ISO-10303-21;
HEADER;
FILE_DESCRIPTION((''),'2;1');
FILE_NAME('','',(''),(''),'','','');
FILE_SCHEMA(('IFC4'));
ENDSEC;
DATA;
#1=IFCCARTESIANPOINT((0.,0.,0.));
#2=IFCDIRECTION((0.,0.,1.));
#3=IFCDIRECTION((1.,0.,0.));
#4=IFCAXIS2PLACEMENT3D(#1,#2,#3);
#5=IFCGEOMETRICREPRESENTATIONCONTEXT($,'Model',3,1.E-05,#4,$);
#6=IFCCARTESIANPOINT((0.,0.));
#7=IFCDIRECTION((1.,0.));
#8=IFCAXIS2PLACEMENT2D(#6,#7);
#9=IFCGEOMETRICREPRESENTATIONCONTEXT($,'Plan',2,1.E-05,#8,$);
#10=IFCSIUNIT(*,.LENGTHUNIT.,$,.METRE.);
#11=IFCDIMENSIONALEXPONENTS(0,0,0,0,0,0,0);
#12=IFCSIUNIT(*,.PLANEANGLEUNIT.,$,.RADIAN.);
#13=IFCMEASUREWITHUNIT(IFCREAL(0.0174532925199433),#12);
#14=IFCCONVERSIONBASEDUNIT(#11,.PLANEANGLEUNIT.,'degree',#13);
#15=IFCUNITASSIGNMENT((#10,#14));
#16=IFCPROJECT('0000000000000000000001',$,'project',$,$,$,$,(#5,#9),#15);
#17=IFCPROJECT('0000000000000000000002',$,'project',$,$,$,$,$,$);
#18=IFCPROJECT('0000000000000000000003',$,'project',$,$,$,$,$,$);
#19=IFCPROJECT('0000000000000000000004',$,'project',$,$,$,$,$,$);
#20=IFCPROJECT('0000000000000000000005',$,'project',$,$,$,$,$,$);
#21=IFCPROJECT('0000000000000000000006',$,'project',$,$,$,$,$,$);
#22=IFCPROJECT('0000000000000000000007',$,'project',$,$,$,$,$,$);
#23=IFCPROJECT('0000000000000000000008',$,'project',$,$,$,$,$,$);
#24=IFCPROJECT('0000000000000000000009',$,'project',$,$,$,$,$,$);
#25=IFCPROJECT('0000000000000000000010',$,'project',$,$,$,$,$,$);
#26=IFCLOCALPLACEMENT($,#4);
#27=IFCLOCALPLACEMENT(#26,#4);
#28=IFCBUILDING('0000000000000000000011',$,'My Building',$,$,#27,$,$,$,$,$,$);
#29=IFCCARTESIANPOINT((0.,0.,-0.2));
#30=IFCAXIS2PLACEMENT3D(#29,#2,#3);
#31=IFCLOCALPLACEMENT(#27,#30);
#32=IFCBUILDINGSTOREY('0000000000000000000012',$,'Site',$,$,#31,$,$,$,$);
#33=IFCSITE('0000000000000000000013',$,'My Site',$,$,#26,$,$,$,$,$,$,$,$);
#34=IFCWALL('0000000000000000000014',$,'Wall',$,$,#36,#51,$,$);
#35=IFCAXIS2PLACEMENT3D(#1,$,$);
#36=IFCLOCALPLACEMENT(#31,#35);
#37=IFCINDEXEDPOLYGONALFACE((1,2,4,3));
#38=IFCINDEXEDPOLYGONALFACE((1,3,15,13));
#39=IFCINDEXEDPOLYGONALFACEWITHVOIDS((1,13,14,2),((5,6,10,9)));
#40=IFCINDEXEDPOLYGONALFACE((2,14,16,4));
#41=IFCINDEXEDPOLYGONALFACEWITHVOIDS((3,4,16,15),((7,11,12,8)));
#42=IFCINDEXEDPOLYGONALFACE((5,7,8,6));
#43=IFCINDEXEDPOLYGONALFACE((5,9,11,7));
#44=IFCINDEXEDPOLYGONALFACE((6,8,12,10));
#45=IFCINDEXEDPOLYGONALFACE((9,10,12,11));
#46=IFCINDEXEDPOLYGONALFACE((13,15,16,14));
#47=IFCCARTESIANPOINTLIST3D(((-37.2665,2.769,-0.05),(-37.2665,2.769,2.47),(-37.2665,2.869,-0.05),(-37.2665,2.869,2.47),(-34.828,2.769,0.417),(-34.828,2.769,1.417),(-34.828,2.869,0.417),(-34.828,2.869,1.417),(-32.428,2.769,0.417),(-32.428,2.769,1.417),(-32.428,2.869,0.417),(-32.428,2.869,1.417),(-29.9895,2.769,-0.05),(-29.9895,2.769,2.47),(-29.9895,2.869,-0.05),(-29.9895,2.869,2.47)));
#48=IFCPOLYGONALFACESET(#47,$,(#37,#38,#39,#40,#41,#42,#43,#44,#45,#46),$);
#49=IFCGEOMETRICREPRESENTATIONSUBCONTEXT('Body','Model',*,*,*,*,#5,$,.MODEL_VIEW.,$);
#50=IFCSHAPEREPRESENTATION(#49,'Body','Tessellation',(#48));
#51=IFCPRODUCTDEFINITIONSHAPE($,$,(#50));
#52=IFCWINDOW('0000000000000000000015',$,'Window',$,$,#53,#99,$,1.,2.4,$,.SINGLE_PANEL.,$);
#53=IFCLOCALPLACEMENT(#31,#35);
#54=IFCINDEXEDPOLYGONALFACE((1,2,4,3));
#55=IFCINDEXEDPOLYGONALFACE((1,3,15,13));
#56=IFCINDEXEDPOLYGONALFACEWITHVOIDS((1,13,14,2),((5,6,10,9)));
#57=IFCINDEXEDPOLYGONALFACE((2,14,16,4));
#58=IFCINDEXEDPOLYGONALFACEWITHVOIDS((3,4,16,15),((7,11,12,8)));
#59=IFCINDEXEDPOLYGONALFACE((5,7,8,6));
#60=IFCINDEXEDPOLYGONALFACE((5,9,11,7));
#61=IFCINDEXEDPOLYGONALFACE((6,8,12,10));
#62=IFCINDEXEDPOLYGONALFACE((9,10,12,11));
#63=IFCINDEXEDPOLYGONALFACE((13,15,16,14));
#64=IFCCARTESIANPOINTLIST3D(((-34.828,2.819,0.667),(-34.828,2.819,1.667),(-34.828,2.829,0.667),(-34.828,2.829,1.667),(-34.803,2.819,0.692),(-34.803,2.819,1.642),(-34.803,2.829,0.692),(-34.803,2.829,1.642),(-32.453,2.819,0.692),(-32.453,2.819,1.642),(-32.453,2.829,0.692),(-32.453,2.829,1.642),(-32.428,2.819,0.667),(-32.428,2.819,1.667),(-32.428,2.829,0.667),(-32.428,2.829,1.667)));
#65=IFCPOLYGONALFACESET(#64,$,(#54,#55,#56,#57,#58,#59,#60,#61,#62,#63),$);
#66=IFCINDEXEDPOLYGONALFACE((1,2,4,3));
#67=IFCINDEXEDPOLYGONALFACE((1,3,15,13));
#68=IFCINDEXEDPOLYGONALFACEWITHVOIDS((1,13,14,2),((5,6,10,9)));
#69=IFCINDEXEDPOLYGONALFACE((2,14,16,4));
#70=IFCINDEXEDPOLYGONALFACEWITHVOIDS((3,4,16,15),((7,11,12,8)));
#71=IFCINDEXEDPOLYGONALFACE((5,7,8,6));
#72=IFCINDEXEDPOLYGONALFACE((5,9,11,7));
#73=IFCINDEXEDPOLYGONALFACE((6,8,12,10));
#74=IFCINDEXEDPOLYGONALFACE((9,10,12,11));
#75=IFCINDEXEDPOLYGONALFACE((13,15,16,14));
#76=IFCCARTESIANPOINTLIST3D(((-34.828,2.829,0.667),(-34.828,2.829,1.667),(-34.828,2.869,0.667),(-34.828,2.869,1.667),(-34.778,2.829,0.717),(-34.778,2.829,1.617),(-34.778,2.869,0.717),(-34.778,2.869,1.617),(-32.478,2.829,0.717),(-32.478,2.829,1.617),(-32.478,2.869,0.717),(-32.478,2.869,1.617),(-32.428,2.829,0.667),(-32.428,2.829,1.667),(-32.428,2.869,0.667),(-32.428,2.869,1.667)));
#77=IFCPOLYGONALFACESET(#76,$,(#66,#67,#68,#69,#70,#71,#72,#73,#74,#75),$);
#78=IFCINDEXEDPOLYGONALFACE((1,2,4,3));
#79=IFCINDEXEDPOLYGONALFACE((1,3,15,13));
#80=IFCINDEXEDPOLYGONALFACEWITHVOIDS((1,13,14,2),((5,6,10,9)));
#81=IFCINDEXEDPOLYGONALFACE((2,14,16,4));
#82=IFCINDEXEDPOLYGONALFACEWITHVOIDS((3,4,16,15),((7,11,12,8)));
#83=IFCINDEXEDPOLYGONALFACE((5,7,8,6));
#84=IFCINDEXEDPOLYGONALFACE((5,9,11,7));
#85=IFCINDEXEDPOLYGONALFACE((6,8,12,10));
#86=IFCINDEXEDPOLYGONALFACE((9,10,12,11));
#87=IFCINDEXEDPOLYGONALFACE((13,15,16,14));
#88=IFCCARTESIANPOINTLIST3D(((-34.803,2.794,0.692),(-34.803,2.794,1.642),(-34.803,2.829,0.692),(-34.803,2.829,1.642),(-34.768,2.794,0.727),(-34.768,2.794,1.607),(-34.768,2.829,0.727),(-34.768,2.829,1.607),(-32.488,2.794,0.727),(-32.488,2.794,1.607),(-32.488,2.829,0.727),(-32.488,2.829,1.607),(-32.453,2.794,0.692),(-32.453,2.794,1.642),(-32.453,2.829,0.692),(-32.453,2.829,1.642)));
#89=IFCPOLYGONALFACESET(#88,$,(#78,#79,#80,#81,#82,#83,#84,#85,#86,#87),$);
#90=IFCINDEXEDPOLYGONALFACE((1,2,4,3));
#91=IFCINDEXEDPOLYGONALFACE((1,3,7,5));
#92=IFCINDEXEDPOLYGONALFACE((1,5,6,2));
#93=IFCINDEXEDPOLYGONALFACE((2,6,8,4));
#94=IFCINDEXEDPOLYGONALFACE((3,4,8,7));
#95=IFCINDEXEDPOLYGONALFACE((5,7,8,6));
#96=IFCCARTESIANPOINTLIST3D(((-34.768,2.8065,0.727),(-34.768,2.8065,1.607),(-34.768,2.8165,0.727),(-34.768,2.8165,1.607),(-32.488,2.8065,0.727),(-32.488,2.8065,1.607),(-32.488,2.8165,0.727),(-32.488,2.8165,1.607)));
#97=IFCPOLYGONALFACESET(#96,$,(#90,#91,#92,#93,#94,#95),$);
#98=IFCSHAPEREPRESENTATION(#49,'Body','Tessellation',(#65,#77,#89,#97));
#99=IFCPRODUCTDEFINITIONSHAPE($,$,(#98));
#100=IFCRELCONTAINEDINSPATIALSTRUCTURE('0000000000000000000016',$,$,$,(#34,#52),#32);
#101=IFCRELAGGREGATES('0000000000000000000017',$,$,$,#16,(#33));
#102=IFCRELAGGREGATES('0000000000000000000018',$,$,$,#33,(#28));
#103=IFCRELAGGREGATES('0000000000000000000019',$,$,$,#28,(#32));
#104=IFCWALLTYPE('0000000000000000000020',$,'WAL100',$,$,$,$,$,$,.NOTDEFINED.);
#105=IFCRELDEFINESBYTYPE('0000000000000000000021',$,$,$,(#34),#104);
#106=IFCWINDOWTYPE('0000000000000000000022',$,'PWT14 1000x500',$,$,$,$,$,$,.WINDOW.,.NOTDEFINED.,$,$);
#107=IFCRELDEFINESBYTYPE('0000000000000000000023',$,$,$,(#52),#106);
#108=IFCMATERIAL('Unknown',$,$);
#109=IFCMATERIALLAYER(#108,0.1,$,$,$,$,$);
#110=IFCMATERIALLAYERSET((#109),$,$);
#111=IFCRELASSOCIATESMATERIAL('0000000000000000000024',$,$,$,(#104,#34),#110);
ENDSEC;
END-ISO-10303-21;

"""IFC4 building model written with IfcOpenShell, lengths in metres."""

from ifc_helpers import new_model, entity, si_unit, converted_unit, frame, origin_with_axes, origin_2d_with_axis, place, context, subcontext, project, spatial, line, indexed_curve, outline, extrude, shape, source, transform, mapped, material, layer, layer_set, layer_usage, type_object, type_shapes, element, fill, save


model = new_model("IFC4")

# Units and contexts
model_context = context("Model", 3, precision=1e-05, world=origin_with_axes())
plan_context = context("Plan", 2, precision=1e-05, world=origin_2d_with_axis())
body_context_1 = subcontext(model_context, "Body", "Model", "MODEL_VIEW")
body_context_2 = subcontext(plan_context, "Body", "Plan", "PLAN_VIEW")
ifc_project_1 = project(units=[si_unit("LENGTHUNIT", "METRE"), converted_unit("PLANEANGLEUNIT", "degree", entity("IfcReal", 0.0174532925199433), si_unit("PLANEANGLEUNIT", "RADIAN"), dimensions=[0, 0, 0, 0, 0, 0, 0])], contexts=[model_context, plan_context])
ifc_project_2 = project()
ifc_project_3 = project()
ifc_project_4 = project()
ifc_project_5 = project()
ifc_project_6 = project()
ifc_project_7 = project()
ifc_project_8 = project()
ifc_project_9 = project()
ifc_project_10 = project()

# Site, building, storey
site_placement = place(None, origin_with_axes())
site = spatial("IfcSite", under=ifc_project_1, at=site_placement, Name="My Site")
building_placement = place(site_placement, origin_with_axes())
building = spatial("IfcBuilding", under=site, at=building_placement, Name="My Building")
storey_placement = place(building_placement, frame((0.0, 0.0, -0.2), z_axis=(0.0, 0.0, 1.0), x_axis=(1.0, 0.0, 0.0)))
storey = spatial("IfcBuildingStorey", under=building, at=storey_placement, Name="Site")

# Shared definitions
ifc_material = material(Name="Unknown")
ifc_layer = layer(ifc_material, 0.1)
ifc_layer_set = layer_set([ifc_layer])
wall_type = type_object("IfcWallType", Name="WAL100", PredefinedType="NOTDEFINED", material=ifc_layer_set)

# Wall, opening, window
ifc_layer_usage_1 = layer_usage(ifc_layer_set, "AXIS2", "POSITIVE", 0.0)
wall_1_placement = place(storey_placement, frame((-29.9895, 2.869, -0.05), z_axis=(0.0, 0.0, 1.0), x_axis=(-1.0, 0.0, 0.0)))
wall_1 = element("IfcWall", 1, at=wall_1_placement, inside=storey, type_object=wall_type, material=ifc_layer_usage_1, Name="Wall", context=body_context_1, shape_type="SweptSolid", body=[
    extrude(outline(indexed_curve([(0.0, 0.0), (0.0, 0.1), (7.277, 0.1), (7.277, 0.0), (0.0, 0.0)], self_intersect=False)), origin_with_axes(), (0.0, 0.0, 1.0), 2.52),
])
shared_shape_1 = source(origin_with_axes(), body_context_1, "Body", "SweptSolid", [
    extrude(outline(indexed_curve([(0.0, 0.0), (2.4, 0.0), (2.4, 1.0), (0.0, 1.0)], segments=[line(1, 2, 2, 3, 3, 4, 4, 1)])), frame((0.0, -0.1, 0.0), z_axis=(0.0, -1.0, 0.0), x_axis=(1.0, 0.0, 0.0)), (0.0, 0.0, -1.0), 0.3),
])
opening_placement = place(wall_1_placement, frame((2.4385, 0.0, 0.467), z_axis=(0.0, 0.0, 1.0), x_axis=(1.0, 0.0, 0.0)))
opening = element("IfcOpeningElement", 2, at=opening_placement, cuts=wall_1, PredefinedType="OPENING", context=body_context_1, shape_type="MappedRepresentation", body=[
    mapped(shared_shape_1, transform((0.0, 0.0, 0.0), x_axis=(1.0, 0.0, 0.0), y_axis=(0.0, 1.0, 0.0), z_axis=(0.0, 0.0, 1.0), scale=1.0)),
])
window_type = type_object("IfcWindowType", Name="PWT14 1000x500", PartitioningType="NOTDEFINED", PredefinedType="WINDOW")
shared_shape_2 = source(origin_with_axes(), body_context_1, "Body", "SweptSolid", [
    extrude(outline(indexed_curve([(0.0, 0.0), (2.4, 0.0), (2.4, 1.0), (0.0, 1.0)], segments=[line(1, 2, 2, 3, 3, 4, 4, 1)]), holes=[indexed_curve([(0.025, 0.025), (2.375, 0.025), (2.375, 0.975), (0.025, 0.975)], segments=[line(1, 2, 2, 3, 3, 4, 4, 1)])]), frame((0.0, 0.04, 0.0), z_axis=(0.0, -1.0, 0.0), x_axis=(1.0, 0.0, 0.0)), (0.0, 0.0, -1.0), 0.01),
    extrude(outline(indexed_curve([(0.0, 0.0), (2.4, 0.0), (2.4, 1.0), (0.0, 1.0)], segments=[line(1, 2, 2, 3, 3, 4, 4, 1)]), holes=[indexed_curve([(0.05, 0.05), (2.35, 0.05), (2.35, 0.95), (0.05, 0.95)], segments=[line(1, 2, 2, 3, 3, 4, 4, 1)])]), frame((0.0, 0.0, 0.0), z_axis=(0.0, -1.0, 0.0), x_axis=(1.0, 0.0, 0.0)), (0.0, 0.0, -1.0), 0.04),
    extrude(outline(indexed_curve([(0.0, 0.0), (2.35, 0.0), (2.35, 0.95), (0.0, 0.95)], segments=[line(1, 2, 2, 3, 3, 4, 4, 1)]), holes=[indexed_curve([(0.035, 0.035), (2.315, 0.035), (2.315, 0.915), (0.035, 0.915)], segments=[line(1, 2, 2, 3, 3, 4, 4, 1)])]), frame((0.025, 0.04, 0.025), z_axis=(0.0, -1.0, 0.0), x_axis=(1.0, 0.0, 0.0)), (0.0, 0.0, -1.0), 0.035),
    extrude(outline(indexed_curve([(0.035, 0.035), (2.315, 0.035), (2.315, 0.915), (0.035, 0.915)], segments=[line(1, 2, 2, 3, 3, 4, 4, 1)])), frame((0.025, 0.0525, 0.025), z_axis=(0.0, -1.0, 0.0), x_axis=(1.0, 0.0, 0.0)), (0.0, 0.0, -1.0), 0.01),
])
shared_shape_3 = source(origin_with_axes(), body_context_2, "Body", "Curve2D", [
    entity("IfcIndexedPolyCurve", entity("IfcCartesianPointList2D", [[0.05, 0.0], [2.35, 0.0]]), [entity("IfcLineIndex", [1, 2])]),
    entity("IfcIndexedPolyCurve", entity("IfcCartesianPointList2D", [[0.0, 0.05], [0.025, 0.05], [0.025, 0.04], [0.05, 0.04], [0.05, 0.0], [0.0, 0.0]]), [entity("IfcLineIndex", [1, 2, 2, 3, 3, 4, 4, 5, 5, 6, 6, 1])]),
    entity("IfcIndexedPolyCurve", entity("IfcCartesianPointList2D", [[2.4, 0.05], [2.375, 0.05], [2.375, 0.04], [2.35, 0.04], [2.35, 0.0], [2.4, 0.0]]), [entity("IfcLineIndex", [1, 2, 2, 3, 3, 4, 4, 5, 5, 6, 6, 1])]),
    entity("IfcIndexedPolyCurve", entity("IfcCartesianPointList2D", [[0.025, 0.04], [0.06, 0.04], [0.06, 0.075], [0.025, 0.075]]), [entity("IfcLineIndex", [1, 2, 2, 3, 3, 4, 4, 1])]),
    entity("IfcIndexedPolyCurve", entity("IfcCartesianPointList2D", [[2.375, 0.04], [2.34, 0.04], [2.34, 0.075], [2.375, 0.075]]), [entity("IfcLineIndex", [1, 2, 2, 3, 3, 4, 4, 1])]),
    entity("IfcIndexedPolyCurve", entity("IfcCartesianPointList2D", [[0.06, 0.04], [2.34, 0.04]]), [entity("IfcLineIndex", [1, 2])]),
    entity("IfcIndexedPolyCurve", entity("IfcCartesianPointList2D", [[0.06, 0.075], [2.34, 0.075]]), [entity("IfcLineIndex", [1, 2])]),
    entity("IfcIndexedPolyCurve", entity("IfcCartesianPointList2D", [[0.06, 0.0575], [2.34, 0.0575]]), [entity("IfcLineIndex", [1, 2])]),
])
type_shapes(window_type, [shared_shape_2, shared_shape_3])
window_placement = place(opening_placement, frame((0.0, 0.0, 0.25), z_axis=(0.0, 0.0, 1.0), x_axis=(1.0, 0.0, 0.0)))
window = element("IfcWindow", 3, at=window_placement, inside=storey, type_object=window_type, Name="Window", OverallHeight=1.0, OverallWidth=2.4, PartitioningType="SINGLE_PANEL", shapes=[
    shape(body_context_1, "Body", "MappedRepresentation", [mapped(shared_shape_2, transform((0.0, 0.0, 0.0), x_axis=(1.0, 0.0, 0.0), y_axis=(0.0, 1.0, 0.0), z_axis=(0.0, 0.0, 1.0), scale=1.0))]),
    shape(body_context_2, "Body", "MappedRepresentation", [mapped(shared_shape_3, transform((0.0, 0.0, 0.0), x_axis=(1.0, 0.0, 0.0), y_axis=(0.0, 1.0, 0.0), z_axis=(0.0, 0.0, 1.0), scale=1.0))]),
])
fill(opening, window)

save(model, "model.ifc")
